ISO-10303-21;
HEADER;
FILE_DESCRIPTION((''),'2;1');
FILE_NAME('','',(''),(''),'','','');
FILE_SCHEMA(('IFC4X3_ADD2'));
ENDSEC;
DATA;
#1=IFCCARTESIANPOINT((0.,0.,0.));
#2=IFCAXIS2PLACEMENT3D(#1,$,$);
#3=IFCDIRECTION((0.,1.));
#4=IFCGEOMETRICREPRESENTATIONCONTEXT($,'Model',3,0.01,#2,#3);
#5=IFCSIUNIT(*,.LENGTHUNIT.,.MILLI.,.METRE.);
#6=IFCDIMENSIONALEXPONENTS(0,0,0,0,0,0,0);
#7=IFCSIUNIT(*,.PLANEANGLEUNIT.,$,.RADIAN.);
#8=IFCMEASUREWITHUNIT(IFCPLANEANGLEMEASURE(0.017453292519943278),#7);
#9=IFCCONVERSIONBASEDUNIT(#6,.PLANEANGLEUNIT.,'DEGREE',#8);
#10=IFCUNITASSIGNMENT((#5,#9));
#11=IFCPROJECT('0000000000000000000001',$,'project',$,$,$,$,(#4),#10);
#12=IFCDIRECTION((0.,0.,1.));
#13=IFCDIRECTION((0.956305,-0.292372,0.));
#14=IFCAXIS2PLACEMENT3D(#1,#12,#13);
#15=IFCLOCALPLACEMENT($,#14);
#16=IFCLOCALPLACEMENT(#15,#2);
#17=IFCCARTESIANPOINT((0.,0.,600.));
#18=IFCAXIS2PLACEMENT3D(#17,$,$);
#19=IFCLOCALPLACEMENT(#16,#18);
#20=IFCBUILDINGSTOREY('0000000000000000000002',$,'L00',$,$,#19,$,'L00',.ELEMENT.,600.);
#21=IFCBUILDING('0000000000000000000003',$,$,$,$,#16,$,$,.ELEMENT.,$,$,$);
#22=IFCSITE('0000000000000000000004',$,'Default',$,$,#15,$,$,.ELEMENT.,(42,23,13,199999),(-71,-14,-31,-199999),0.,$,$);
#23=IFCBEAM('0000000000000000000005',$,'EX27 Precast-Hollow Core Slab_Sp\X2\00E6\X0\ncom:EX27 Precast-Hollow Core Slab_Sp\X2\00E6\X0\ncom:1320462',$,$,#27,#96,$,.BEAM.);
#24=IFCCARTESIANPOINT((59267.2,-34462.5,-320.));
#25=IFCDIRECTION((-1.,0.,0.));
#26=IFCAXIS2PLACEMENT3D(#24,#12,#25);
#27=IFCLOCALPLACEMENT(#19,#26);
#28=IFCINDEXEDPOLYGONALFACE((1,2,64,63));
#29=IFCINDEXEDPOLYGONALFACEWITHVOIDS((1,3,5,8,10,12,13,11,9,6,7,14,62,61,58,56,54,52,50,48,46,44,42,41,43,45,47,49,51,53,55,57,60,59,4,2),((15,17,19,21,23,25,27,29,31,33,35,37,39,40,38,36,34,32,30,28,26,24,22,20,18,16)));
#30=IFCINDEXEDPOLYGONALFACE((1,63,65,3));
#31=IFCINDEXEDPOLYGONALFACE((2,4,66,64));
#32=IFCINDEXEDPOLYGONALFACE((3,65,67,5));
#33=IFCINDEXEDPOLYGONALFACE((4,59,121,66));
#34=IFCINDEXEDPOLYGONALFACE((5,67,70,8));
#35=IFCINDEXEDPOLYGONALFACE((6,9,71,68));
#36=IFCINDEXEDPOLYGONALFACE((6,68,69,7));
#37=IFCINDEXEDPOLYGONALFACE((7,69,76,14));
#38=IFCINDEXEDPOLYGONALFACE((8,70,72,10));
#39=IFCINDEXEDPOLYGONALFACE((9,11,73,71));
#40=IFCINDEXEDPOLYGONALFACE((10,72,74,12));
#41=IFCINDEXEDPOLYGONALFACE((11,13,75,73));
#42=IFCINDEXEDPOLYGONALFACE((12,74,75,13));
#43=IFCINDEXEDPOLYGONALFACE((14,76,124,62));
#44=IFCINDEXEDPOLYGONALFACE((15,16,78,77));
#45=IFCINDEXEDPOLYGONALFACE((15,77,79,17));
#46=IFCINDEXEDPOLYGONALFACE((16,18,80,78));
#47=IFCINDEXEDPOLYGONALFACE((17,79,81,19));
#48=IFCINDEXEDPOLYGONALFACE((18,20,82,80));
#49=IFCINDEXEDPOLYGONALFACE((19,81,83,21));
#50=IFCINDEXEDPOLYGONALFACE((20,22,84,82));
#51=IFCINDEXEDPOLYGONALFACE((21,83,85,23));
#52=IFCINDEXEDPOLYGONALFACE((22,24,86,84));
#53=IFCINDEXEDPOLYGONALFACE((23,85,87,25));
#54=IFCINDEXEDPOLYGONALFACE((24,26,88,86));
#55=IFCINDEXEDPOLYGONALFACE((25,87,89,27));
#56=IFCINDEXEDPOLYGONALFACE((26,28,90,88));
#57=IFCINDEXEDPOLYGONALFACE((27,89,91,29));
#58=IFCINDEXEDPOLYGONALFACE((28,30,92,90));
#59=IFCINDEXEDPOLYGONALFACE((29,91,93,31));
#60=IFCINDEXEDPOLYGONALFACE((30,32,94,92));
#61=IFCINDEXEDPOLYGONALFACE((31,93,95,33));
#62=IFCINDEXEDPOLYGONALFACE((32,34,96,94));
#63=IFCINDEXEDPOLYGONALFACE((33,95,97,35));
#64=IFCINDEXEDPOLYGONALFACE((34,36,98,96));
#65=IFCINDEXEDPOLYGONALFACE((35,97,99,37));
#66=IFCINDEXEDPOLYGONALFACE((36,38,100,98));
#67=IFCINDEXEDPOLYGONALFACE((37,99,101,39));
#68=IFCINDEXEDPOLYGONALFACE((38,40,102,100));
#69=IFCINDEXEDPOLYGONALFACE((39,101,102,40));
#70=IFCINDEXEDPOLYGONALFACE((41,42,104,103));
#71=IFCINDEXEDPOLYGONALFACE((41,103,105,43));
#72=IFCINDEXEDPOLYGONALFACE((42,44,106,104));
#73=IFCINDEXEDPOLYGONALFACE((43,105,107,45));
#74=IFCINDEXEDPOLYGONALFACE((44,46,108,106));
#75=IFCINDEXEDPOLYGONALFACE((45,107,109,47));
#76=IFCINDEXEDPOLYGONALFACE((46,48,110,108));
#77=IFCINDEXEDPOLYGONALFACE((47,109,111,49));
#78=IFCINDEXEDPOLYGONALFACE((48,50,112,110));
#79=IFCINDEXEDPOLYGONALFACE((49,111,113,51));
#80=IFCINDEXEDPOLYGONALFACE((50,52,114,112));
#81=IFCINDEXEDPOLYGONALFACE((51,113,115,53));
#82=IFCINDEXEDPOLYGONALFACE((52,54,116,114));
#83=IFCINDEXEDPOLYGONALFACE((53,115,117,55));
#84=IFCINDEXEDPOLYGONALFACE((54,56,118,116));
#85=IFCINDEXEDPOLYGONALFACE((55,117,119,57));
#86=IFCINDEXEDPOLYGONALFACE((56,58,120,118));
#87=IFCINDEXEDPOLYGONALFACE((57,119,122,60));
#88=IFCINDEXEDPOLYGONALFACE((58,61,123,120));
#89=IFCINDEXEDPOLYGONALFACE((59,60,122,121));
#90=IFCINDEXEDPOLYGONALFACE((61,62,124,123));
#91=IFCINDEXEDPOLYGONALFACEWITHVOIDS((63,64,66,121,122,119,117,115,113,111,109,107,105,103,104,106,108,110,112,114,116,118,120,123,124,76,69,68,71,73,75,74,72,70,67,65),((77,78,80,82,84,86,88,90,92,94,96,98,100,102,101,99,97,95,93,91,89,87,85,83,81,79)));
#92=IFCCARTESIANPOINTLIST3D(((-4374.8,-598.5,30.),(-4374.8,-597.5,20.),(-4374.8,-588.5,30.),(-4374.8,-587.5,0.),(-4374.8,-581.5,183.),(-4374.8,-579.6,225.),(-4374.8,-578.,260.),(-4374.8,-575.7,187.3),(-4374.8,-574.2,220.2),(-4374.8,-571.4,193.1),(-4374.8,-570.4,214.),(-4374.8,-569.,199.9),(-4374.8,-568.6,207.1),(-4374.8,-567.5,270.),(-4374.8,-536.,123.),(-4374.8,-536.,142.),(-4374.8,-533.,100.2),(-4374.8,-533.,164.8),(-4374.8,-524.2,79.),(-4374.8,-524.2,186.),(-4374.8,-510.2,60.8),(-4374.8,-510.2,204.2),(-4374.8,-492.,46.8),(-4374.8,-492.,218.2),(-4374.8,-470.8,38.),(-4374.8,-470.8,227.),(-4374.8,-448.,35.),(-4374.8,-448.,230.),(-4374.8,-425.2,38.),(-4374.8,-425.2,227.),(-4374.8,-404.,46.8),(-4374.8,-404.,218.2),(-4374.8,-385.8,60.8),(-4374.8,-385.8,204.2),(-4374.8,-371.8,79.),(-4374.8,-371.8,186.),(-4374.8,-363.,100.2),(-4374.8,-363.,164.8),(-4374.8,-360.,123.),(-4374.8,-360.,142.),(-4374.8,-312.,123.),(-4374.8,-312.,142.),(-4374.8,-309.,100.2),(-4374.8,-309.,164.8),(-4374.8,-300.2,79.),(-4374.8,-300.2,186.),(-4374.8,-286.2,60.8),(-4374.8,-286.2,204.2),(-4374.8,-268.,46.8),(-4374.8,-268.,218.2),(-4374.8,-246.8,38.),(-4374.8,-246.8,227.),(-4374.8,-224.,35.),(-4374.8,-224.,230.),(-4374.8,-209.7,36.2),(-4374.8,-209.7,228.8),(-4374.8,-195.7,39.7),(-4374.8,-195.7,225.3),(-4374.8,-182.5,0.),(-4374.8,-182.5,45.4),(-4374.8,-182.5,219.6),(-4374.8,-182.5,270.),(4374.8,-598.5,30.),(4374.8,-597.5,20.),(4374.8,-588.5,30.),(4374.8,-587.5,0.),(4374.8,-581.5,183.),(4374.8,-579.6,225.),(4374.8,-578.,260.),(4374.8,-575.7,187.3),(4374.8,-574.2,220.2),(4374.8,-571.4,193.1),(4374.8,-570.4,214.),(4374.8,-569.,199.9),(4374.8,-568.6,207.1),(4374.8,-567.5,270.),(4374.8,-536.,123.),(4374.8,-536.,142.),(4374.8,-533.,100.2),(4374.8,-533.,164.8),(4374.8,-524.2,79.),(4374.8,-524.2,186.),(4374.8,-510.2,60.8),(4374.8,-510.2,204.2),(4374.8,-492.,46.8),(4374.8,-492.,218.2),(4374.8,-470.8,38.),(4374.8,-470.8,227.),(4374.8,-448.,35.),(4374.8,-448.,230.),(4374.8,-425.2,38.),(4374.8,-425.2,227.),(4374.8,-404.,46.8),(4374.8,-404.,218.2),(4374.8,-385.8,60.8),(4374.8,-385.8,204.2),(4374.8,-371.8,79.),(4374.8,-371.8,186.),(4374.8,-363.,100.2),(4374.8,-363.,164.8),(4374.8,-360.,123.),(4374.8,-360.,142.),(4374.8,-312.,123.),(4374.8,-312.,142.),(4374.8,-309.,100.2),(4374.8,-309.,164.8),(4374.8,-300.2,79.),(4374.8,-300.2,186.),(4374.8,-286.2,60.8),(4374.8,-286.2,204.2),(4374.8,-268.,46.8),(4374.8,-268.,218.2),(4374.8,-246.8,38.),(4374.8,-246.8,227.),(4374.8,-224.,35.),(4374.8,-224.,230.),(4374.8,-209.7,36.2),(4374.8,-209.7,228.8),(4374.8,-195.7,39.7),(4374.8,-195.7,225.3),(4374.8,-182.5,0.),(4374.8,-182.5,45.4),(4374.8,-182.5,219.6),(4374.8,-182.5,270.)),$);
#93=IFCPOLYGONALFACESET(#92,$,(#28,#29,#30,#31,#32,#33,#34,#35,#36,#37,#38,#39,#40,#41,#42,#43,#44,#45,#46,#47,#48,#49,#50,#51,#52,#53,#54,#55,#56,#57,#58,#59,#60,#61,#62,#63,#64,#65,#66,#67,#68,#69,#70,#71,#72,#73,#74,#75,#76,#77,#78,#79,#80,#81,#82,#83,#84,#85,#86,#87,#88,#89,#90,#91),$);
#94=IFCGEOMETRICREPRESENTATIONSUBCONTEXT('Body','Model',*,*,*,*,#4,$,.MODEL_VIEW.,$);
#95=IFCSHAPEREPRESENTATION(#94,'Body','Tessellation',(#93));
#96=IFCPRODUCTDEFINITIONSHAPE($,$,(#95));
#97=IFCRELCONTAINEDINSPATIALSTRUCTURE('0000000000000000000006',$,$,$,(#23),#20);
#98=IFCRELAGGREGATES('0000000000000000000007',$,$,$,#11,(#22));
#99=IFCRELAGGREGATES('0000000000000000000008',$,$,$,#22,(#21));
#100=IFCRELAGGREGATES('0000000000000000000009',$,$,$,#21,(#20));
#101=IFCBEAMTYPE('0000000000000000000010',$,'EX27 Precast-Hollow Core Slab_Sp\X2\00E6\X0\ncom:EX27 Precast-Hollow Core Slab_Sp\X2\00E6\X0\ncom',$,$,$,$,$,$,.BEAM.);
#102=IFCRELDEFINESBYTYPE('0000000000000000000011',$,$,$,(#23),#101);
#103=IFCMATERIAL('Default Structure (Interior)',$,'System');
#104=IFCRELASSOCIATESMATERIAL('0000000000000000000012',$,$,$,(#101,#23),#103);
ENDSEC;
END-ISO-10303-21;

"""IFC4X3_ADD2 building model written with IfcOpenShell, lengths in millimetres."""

from ifc_helpers import new_model, entity, si_unit, converted_unit, direction, frame, frame_2d, origin, place, context, subcontext, project, spatial, polyline, circle_curve, parameter, trimmed, segment, composite_curve, outline, extrude, source, transform, mapped, material, material_profile, profile_set, profile_usage, type_object, type_shapes, element, save


model = new_model("IFC4X3_ADD2")

# Units and contexts
model_context = context("Model", 3, precision=0.01, world=origin(), true_north=direction((0.0, 1.0)))
body_context = subcontext(model_context, "Body", "Model", "MODEL_VIEW")
ifc_project = project(units=[si_unit("LENGTHUNIT", "METRE", prefix="MILLI"), converted_unit("PLANEANGLEUNIT", "DEGREE", entity("IfcPlaneAngleMeasure", 0.017453292519943278), si_unit("PLANEANGLEUNIT", "RADIAN"), dimensions=[0, 0, 0, 0, 0, 0, 0])], contexts=[model_context])

# Site, building, storey
site_placement = place(None, frame((0.0, 0.0, 0.0), z_axis=(0.0, 0.0, 1.0), x_axis=(0.956305, -0.292372, 0.0)))
site = spatial("IfcSite", under=ifc_project, at=site_placement, Name="Default", CompositionType="ELEMENT", RefLatitude=(42, 23, 13, 199999), RefLongitude=(-71, -14, -31, -199999), RefElevation=0.0)
building_placement = place(site_placement, origin())
building = spatial("IfcBuilding", under=site, at=building_placement, CompositionType="ELEMENT")
storey_placement = place(building_placement, frame((0.0, 0.0, 600.0)))
storey = spatial("IfcBuildingStorey", under=building, at=storey_placement, Name="L00", LongName="L00", CompositionType="ELEMENT", Elevation=600.0)

# Beam
ifc_material_1 = material(Name="Default Structure (Interior)", Category="System")
ifc_material_profile_1 = material_profile(ifc_material_1, outline(composite_curve([segment(polyline([(-124.1, 583.4), (-124.6, 593.4)]), True, "CONTINUOUS"), segment(polyline([(-124.6, 593.4), (-134.5, 592.0)]), True, "CONTINUOUS"), segment(polyline([(-134.5, 592.0), (-154.0, 581.1)]), True, "CONTINUOUS"), segment(polyline([(-154.0, 581.1), (-100.2, -592.7)]), True, "CONTINUOUS"), segment(polyline([(-100.2, -592.7), (-79.8, -601.8)]), True, "CONTINUOUS"), segment(polyline([(-79.8, -601.8), (-69.7, -602.3)]), True, "CONTINUOUS"), segment(polyline([(-69.7, -602.3), (-70.2, -592.3)]), True, "CONTINUOUS"), segment(polyline([(-70.2, -592.3), (82.3, -578.3)]), True, "CONTINUOUS"), segment(trimmed(circle_curve(frame_2d((104.4, -588.8), x_axis=(0.045785, -0.998951)), 24.4), [parameter(123.160759)], [parameter(242.087681)], True, "PARAMETER"), False, "CONTINUOUS"), segment(polyline([(124.2, -574.5), (159.1, -571.3)]), True, "CONTINUOUS"), segment(polyline([(159.1, -571.3), (168.6, -560.4)]), True, "CONTINUOUS"), segment(polyline([(168.6, -560.4), (116.6, 573.4)]), True, "CONTINUOUS"), segment(polyline([(116.6, 573.4), (106.2, 583.4)]), True, "CONTINUOUS"), segment(polyline([(106.2, 583.4), (71.1, 583.4)]), True, "CONTINUOUS"), segment(trimmed(circle_curve(frame_2d((50.1, 595.8), x_axis=(0.045785, -0.998951)), 24.4), [parameter(297.912319)], [parameter(56.839241)], True, "PARAMETER"), False, "CONTINUOUS"), segment(polyline([(29.1, 583.4), (-124.1, 583.4)]), True, "CONTINUOUS")], self_intersect=False), holes=[composite_curve([segment(polyline([(39.3, -534.8), (20.3, -535.6)]), True, "CONTINUOUS"), segment(trimmed(circle_curve(frame_2d((16.3, -447.7), x_axis=(0.045785, -0.998951)), 88.0), [parameter(270.0)], [parameter(0.0)], True, "PARAMETER"), False, "CONTINUOUS"), segment(trimmed(circle_curve(frame_2d((16.3, -447.7), x_axis=(0.045785, -0.998951)), 88.0), [parameter(180.0)], [parameter(270.0)], True, "PARAMETER"), False, "CONTINUOUS"), segment(polyline([(12.2, -359.8), (31.2, -358.9)]), True, "CONTINUOUS"), segment(trimmed(circle_curve(frame_2d((35.2, -446.9), x_axis=(0.045785, -0.998951)), 88.0), [parameter(90.0)], [parameter(180.0)], True, "PARAMETER"), False, "CONTINUOUS"), segment(trimmed(circle_curve(frame_2d((35.2, -446.9), x_axis=(0.045785, -0.998951)), 88.0), [parameter(0.0)], [parameter(90.0)], True, "PARAMETER"), False, "CONTINUOUS")], self_intersect=False), composite_curve([segment(trimmed(circle_curve(frame_2d((6.0, -224.0), x_axis=(0.045785, -0.998951)), 88.0), [parameter(180.0)], [parameter(270.0)], True, "PARAMETER"), False, "CONTINUOUS"), segment(polyline([(2.0, -136.1), (21.0, -135.2)]), True, "CONTINUOUS"), segment(trimmed(circle_curve(frame_2d((25.0, -223.1), x_axis=(0.045785, -0.998951)), 88.0), [parameter(90.0)], [parameter(180.0)], True, "PARAMETER"), False, "CONTINUOUS"), segment(trimmed(circle_curve(frame_2d((25.0, -223.1), x_axis=(0.045785, -0.998951)), 88.0), [parameter(0.0)], [parameter(90.0)], True, "PARAMETER"), False, "CONTINUOUS"), segment(polyline([(29.0, -311.0), (10.0, -311.9)]), True, "CONTINUOUS"), segment(trimmed(circle_curve(frame_2d((6.0, -224.0), x_axis=(0.045785, -0.998951)), 88.0), [parameter(270.0)], [parameter(0.0)], True, "PARAMETER"), False, "CONTINUOUS")], self_intersect=False), composite_curve([segment(trimmed(circle_curve(frame_2d((-4.2, -0.2), x_axis=(0.045785, -0.998951)), 88.0), [parameter(180.0)], [parameter(270.0)], True, "PARAMETER"), False, "CONTINUOUS"), segment(polyline([(-8.3, 87.7), (10.7, 88.6)]), True, "CONTINUOUS"), segment(trimmed(circle_curve(frame_2d((14.7, 0.7), x_axis=(0.045785, -0.998951)), 88.0), [parameter(90.0)], [parameter(180.0)], True, "PARAMETER"), False, "CONTINUOUS"), segment(trimmed(circle_curve(frame_2d((14.7, 0.7), x_axis=(0.045785, -0.998951)), 88.0), [parameter(0.0)], [parameter(90.0)], True, "PARAMETER"), False, "CONTINUOUS"), segment(polyline([(18.8, -87.2), (-0.2, -88.1)]), True, "CONTINUOUS"), segment(trimmed(circle_curve(frame_2d((-4.2, -0.2), x_axis=(0.045785, -0.998951)), 88.0), [parameter(270.0)], [parameter(0.0)], True, "PARAMETER"), False, "CONTINUOUS")], self_intersect=False), composite_curve([segment(trimmed(circle_curve(frame_2d((-14.5, 223.6), x_axis=(0.045785, -0.998951)), 88.0), [parameter(180.0)], [parameter(270.0)], True, "PARAMETER"), False, "CONTINUOUS"), segment(polyline([(-18.5, 311.5), (0.4, 312.3)]), True, "CONTINUOUS"), segment(trimmed(circle_curve(frame_2d((4.5, 224.4), x_axis=(0.045785, -0.998951)), 88.0), [parameter(90.0)], [parameter(180.0)], True, "PARAMETER"), False, "CONTINUOUS"), segment(trimmed(circle_curve(frame_2d((4.5, 224.4), x_axis=(0.045785, -0.998951)), 88.0), [parameter(0.0)], [parameter(90.0)], True, "PARAMETER"), False, "CONTINUOUS"), segment(polyline([(8.5, 136.5), (-10.5, 135.7)]), True, "CONTINUOUS"), segment(trimmed(circle_curve(frame_2d((-14.5, 223.6), x_axis=(0.045785, -0.998951)), 88.0), [parameter(270.0)], [parameter(0.0)], True, "PARAMETER"), False, "CONTINUOUS")], self_intersect=False), composite_curve([segment(trimmed(circle_curve(frame_2d((-24.8, 447.3), x_axis=(0.045785, -0.998951)), 88.0), [parameter(180.0)], [parameter(270.0)], True, "PARAMETER"), False, "CONTINUOUS"), segment(polyline([(-28.8, 535.2), (-9.8, 536.1)]), True, "CONTINUOUS"), segment(trimmed(circle_curve(frame_2d((-5.8, 448.2), x_axis=(0.045785, -0.998951)), 88.0), [parameter(90.0)], [parameter(180.0)], True, "PARAMETER"), False, "CONTINUOUS"), segment(trimmed(circle_curve(frame_2d((-5.8, 448.2), x_axis=(0.045785, -0.998951)), 88.0), [parameter(0.0)], [parameter(90.0)], True, "PARAMETER"), False, "CONTINUOUS"), segment(polyline([(-1.7, 360.3), (-20.7, 359.4)]), True, "CONTINUOUS"), segment(trimmed(circle_curve(frame_2d((-24.8, 447.3), x_axis=(0.045785, -0.998951)), 88.0), [parameter(270.0)], [parameter(0.0)], True, "PARAMETER"), False, "CONTINUOUS")], self_intersect=False)]), Name="EX27 Precast-Hollow Core Slab_Spæncom")
ifc_profile_set_1 = profile_set([ifc_material_profile_1], Name="EX27 Precast-Hollow Core Slab_Spæncom")
ifc_profile_usage_1 = profile_usage(ifc_profile_set_1, cardinal=8)
beam_type_1 = type_object("IfcBeamType", Name="EX27 Precast-Hollow Core Slab_Spæncom:EX27 Precast-Hollow Core Slab_Spæncom", PredefinedType="BEAM", material=ifc_profile_set_1)
shared_shape_1 = source(origin(), body_context, "Body", "SweptSolid", [
    extrude(outline(composite_curve([segment(polyline([(-182.5, -130.2), (222.5, -130.2)]), True, "CONTINUOUS"), segment(polyline([(222.5, -130.2), (222.5, -84.8)]), True, "CONTINUOUS"), segment(trimmed(circle_curve(frame_2d((181.0, -7.2), x_axis=(-1.0, 0.0)), 88.0), [parameter(90.0)], [parameter(118.137616)], True, "PARAMETER"), False, "CONTINUOUS"), segment(trimmed(circle_curve(frame_2d((181.0, -7.2), x_axis=(-1.0, 0.0)), 88.0), [parameter(0.0)], [parameter(90.0)], True, "PARAMETER"), False, "CONTINUOUS"), segment(polyline([(93.0, -7.2), (93.0, 11.8)]), True, "CONTINUOUS"), segment(trimmed(circle_curve(frame_2d((181.0, 11.8), x_axis=(-1.0, 0.0)), 88.0), [parameter(270.0)], [parameter(0.0)], True, "PARAMETER"), False, "CONTINUOUS"), segment(trimmed(circle_curve(frame_2d((181.0, 11.8), x_axis=(-1.0, 0.0)), 88.0), [parameter(241.862384)], [parameter(270.0)], True, "PARAMETER"), False, "CONTINUOUS"), segment(polyline([(222.5, 89.4), (222.5, 139.8)]), True, "CONTINUOUS"), segment(polyline([(222.5, 139.8), (-162.5, 139.8)]), True, "CONTINUOUS"), segment(polyline([(-162.5, 139.8), (-172.9, 129.8)]), True, "CONTINUOUS"), segment(polyline([(-172.9, 129.8), (-174.5, 94.8)]), True, "CONTINUOUS"), segment(trimmed(circle_curve(frame_2d((-187.9, 74.4), x_axis=(-1.0, 0.0)), 24.4), [parameter(117.912319)], [parameter(236.839241)], True, "PARAMETER"), False, "CONTINUOUS"), segment(polyline([(-176.5, 52.8), (-183.5, -100.2)]), True, "CONTINUOUS"), segment(polyline([(-183.5, -100.2), (-193.5, -100.2)]), True, "CONTINUOUS"), segment(polyline([(-193.5, -100.2), (-192.5, -110.2)]), True, "CONTINUOUS"), segment(polyline([(-192.5, -110.2), (-182.5, -130.2)]), True, "CONTINUOUS")], self_intersect=False), holes=[composite_curve([segment(trimmed(circle_curve(frame_2d((-43.0, 11.8), x_axis=(-1.0, 0.0)), 88.0), [parameter(270.0)], [parameter(0.0)], True, "PARAMETER"), False, "CONTINUOUS"), segment(trimmed(circle_curve(frame_2d((-43.0, 11.8), x_axis=(-1.0, 0.0)), 88.0), [parameter(180.0)], [parameter(270.0)], True, "PARAMETER"), False, "CONTINUOUS"), segment(polyline([(45.0, 11.8), (45.0, -7.2)]), True, "CONTINUOUS"), segment(trimmed(circle_curve(frame_2d((-43.0, -7.2), x_axis=(-1.0, 0.0)), 88.0), [parameter(90.0)], [parameter(180.0)], True, "PARAMETER"), False, "CONTINUOUS"), segment(trimmed(circle_curve(frame_2d((-43.0, -7.2), x_axis=(-1.0, 0.0)), 88.0), [parameter(0.0)], [parameter(90.0)], True, "PARAMETER"), False, "CONTINUOUS"), segment(polyline([(-131.0, -7.2), (-131.0, 11.8)]), True, "CONTINUOUS")], self_intersect=False)]), frame((-4374.8, -405.0, 130.2), z_axis=(1.0, 0.0, 0.0), x_axis=(0.0, 1.0, 0.0)), (0.0, 0.0, 1.0), 8749.7),
])
type_shapes(beam_type_1, [shared_shape_1])
beam_1_placement = place(storey_placement, frame((59267.2, -34462.5, -320.0), z_axis=(0.0, 0.0, 1.0), x_axis=(-1.0, 0.0, 0.0)))
element("IfcBeam", 1, at=beam_1_placement, inside=storey, type_object=beam_type_1, material=ifc_profile_usage_1, Name="EX27 Precast-Hollow Core Slab_Spæncom:EX27 Precast-Hollow Core Slab_Spæncom:1320462", PredefinedType="BEAM", context=body_context, shape_type="MappedRepresentation", body=[
    mapped(shared_shape_1, transform((0.0, 0.0, 0.0), scale=1.0)),
])

save(model, "model.ifc")
